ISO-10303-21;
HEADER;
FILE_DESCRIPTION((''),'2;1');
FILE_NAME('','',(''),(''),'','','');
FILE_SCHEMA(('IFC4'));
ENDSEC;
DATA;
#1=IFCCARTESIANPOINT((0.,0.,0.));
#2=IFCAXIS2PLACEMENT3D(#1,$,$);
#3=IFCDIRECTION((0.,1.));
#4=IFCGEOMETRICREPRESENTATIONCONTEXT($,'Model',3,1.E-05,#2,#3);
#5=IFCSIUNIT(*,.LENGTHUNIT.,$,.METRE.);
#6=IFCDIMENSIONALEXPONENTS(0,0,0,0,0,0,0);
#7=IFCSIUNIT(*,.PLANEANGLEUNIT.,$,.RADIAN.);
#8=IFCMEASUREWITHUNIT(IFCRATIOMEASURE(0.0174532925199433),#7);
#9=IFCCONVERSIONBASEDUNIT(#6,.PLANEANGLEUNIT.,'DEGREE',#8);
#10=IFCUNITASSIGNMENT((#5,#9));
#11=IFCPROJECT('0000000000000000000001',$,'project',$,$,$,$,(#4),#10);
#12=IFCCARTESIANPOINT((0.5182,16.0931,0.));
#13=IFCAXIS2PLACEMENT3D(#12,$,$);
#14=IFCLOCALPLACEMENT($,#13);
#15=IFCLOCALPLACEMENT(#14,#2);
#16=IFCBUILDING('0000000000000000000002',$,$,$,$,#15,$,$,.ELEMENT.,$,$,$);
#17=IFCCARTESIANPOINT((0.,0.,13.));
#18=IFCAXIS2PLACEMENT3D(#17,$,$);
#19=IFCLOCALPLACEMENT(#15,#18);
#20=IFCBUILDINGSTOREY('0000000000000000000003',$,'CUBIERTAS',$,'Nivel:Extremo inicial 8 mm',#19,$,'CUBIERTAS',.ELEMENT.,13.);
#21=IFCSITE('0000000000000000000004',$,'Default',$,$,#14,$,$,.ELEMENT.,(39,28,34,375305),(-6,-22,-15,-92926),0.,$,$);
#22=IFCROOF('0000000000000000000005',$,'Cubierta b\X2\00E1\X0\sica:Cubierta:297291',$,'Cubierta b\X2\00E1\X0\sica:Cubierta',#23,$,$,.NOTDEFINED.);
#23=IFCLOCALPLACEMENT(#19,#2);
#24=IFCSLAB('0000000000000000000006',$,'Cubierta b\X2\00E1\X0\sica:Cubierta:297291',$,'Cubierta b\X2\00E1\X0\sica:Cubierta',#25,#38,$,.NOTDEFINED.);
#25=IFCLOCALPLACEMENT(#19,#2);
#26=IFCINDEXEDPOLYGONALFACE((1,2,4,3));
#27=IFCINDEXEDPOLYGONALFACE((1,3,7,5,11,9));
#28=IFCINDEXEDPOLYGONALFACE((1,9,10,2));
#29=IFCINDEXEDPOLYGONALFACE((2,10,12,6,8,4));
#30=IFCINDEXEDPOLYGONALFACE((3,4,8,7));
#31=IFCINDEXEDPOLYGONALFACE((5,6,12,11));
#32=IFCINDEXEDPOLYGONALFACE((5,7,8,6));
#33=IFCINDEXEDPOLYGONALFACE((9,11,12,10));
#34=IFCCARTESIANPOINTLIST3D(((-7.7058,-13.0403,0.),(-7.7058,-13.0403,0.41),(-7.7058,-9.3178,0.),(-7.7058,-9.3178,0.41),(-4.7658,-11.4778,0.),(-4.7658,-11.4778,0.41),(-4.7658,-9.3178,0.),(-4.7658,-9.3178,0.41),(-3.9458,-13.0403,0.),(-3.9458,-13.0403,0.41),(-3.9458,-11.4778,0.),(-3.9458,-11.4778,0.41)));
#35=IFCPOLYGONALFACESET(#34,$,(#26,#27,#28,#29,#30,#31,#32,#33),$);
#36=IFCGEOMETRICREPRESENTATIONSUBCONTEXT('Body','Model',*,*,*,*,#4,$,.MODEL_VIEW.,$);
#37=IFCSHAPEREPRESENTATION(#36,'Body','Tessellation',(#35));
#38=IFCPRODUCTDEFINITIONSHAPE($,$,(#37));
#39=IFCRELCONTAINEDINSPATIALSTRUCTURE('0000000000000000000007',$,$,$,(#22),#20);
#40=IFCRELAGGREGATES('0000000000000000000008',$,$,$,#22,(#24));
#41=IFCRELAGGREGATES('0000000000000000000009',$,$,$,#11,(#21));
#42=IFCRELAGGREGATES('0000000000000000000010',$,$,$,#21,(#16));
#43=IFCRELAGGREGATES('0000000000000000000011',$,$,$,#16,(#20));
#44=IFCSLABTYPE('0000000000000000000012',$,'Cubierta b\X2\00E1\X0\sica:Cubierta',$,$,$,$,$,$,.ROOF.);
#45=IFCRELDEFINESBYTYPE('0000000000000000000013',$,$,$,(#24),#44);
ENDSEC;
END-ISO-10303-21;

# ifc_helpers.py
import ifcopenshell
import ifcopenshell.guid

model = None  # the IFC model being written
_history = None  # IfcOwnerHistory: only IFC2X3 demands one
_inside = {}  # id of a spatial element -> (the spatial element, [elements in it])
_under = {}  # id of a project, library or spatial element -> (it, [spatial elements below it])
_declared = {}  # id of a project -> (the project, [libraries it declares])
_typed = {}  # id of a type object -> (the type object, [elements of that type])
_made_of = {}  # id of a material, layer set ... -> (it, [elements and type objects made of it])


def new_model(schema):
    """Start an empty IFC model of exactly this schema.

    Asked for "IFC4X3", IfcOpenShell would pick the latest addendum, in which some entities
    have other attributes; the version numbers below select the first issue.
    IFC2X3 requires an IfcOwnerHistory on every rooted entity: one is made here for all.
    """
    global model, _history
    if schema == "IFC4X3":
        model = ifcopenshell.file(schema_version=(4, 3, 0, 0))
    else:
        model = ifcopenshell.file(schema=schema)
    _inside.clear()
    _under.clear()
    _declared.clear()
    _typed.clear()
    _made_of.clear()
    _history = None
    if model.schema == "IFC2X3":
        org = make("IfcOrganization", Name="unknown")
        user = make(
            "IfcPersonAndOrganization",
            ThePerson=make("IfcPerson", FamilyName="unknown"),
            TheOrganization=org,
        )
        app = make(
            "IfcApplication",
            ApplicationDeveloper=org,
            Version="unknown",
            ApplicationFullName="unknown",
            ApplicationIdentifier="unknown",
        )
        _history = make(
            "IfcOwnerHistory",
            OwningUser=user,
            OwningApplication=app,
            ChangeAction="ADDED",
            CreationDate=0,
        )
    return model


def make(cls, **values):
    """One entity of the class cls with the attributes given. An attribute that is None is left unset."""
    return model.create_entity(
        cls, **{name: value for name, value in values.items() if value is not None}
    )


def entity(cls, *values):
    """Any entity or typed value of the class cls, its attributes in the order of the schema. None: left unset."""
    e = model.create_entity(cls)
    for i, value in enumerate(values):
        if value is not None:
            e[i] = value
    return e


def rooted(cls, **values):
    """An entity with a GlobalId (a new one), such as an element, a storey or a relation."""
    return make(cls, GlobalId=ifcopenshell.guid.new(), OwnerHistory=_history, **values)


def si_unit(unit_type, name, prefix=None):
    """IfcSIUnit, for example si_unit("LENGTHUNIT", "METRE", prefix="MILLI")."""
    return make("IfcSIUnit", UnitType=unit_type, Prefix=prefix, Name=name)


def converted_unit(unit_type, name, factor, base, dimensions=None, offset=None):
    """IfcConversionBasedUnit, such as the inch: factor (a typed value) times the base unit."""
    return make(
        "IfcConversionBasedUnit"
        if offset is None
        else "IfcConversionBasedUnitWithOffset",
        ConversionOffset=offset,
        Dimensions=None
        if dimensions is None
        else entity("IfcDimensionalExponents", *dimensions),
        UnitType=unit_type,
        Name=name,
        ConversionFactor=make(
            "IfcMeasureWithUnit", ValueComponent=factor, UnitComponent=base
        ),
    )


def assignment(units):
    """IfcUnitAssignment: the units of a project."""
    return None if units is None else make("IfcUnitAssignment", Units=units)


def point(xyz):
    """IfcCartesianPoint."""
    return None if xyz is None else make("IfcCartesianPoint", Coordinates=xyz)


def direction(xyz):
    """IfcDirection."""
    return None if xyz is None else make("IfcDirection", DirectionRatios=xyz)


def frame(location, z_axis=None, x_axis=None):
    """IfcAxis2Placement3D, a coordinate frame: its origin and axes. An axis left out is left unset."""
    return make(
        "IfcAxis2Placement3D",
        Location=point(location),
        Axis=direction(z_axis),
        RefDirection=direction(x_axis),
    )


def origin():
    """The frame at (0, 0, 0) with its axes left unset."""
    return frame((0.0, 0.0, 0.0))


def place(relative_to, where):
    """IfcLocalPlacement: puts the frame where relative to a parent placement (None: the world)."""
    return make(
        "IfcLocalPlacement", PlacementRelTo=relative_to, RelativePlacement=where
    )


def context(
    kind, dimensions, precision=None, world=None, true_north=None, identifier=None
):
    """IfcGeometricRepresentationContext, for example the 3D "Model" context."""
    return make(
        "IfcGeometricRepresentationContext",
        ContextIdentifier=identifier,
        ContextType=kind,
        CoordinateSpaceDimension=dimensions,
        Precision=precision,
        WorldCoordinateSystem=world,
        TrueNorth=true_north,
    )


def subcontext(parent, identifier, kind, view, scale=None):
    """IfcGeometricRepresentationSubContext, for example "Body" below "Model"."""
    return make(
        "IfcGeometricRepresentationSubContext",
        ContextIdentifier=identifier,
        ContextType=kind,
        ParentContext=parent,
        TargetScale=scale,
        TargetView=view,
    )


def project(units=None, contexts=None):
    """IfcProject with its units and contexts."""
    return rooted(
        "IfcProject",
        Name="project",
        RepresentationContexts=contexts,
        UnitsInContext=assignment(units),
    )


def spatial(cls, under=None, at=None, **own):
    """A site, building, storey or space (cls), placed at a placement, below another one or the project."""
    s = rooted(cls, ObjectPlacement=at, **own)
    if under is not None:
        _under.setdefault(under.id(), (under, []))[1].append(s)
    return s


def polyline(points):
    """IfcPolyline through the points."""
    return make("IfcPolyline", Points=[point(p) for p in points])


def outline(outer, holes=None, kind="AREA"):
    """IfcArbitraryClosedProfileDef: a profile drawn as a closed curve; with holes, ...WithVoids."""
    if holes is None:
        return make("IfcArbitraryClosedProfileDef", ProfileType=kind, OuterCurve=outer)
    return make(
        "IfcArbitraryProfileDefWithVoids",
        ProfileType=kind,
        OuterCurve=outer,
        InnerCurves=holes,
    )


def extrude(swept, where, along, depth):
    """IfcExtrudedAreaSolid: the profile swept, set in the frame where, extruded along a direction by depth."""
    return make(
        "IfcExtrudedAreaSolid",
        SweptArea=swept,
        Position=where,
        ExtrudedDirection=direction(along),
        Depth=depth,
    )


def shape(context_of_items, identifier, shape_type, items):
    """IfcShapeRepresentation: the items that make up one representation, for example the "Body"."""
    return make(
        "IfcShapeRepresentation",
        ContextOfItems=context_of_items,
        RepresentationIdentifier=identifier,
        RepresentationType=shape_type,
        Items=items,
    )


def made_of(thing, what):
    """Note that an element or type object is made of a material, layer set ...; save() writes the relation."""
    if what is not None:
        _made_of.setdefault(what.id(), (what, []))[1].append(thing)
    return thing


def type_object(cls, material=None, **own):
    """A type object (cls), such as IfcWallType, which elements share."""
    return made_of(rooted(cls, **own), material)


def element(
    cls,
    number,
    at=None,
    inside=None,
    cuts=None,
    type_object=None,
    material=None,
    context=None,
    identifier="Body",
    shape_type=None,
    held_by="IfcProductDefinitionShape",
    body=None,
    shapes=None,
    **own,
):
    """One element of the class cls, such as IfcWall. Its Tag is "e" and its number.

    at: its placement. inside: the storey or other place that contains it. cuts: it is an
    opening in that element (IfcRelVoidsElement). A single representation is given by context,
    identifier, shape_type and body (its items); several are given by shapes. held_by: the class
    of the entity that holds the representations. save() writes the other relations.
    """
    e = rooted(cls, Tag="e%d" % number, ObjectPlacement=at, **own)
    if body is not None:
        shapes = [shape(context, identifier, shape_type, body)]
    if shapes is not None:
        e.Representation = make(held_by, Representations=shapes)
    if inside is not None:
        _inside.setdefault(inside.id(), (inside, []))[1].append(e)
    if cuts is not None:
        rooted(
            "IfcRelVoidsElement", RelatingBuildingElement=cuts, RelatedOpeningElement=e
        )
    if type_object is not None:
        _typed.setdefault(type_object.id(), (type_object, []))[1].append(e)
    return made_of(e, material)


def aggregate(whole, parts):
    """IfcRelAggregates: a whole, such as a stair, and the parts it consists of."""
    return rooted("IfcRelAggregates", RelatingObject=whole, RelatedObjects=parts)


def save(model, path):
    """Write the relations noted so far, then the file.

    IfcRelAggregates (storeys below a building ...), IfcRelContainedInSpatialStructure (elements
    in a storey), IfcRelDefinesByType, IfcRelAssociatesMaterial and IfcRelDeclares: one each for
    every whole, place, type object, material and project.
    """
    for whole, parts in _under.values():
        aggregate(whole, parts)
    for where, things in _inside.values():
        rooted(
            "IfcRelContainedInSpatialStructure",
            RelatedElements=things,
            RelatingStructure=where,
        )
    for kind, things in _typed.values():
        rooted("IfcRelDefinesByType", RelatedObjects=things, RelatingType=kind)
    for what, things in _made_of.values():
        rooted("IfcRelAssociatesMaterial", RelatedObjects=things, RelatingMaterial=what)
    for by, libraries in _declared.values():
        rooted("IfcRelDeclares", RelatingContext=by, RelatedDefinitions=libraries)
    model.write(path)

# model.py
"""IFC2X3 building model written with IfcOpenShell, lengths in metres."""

from ifc_helpers import new_model, entity, si_unit, converted_unit, direction, frame, origin, place, context, subcontext, project, spatial, polyline, outline, extrude, type_object, element, aggregate, save


model = new_model("IFC2X3")

# Units and contexts
model_context = context("Model", 3, precision=1e-05, world=origin(), true_north=direction((0.0, 1.0)))
body_context = subcontext(model_context, "Body", "Model", "MODEL_VIEW")
ifc_project = project(units=[si_unit("LENGTHUNIT", "METRE"), converted_unit("PLANEANGLEUNIT", "DEGREE", entity("IfcRatioMeasure", 0.0174532925199433), si_unit("PLANEANGLEUNIT", "RADIAN"), dimensions=[0, 0, 0, 0, 0, 0, 0])], contexts=[model_context])

# Site, building, storey
site_placement = place(None, frame((0.5182, 16.0931, 0.0)))
site = spatial("IfcSite", under=ifc_project, at=site_placement, Name="Default", CompositionType="ELEMENT", RefLatitude=(39, 28, 34, 375305), RefLongitude=(-6, -22, -15, -92926), RefElevation=0.0)
building_placement = place(site_placement, origin())
building = spatial("IfcBuilding", under=site, at=building_placement, CompositionType="ELEMENT")
storey_placement = place(building_placement, frame((0.0, 0.0, 13.0)))
storey = spatial("IfcBuildingStorey", under=building, at=storey_placement, Name="CUBIERTAS", ObjectType="Nivel:Extremo inicial 8 mm", LongName="CUBIERTAS", CompositionType="ELEMENT", Elevation=13.0)

# Roof, slab
roof_placement = place(storey_placement, frame((-7.7058, -13.0403, 0.0)))
roof = element("IfcRoof", 1, at=roof_placement, inside=storey, Name="Cubierta básica:Cubierta:297291", ObjectType="Cubierta básica:Cubierta", ShapeType="NOTDEFINED")
slab_type = type_object("IfcSlabType", Name="Cubierta básica:Cubierta", PredefinedType="ROOF")
slab_placement = place(roof_placement, origin())
slab = element("IfcSlab", 2, at=slab_placement, type_object=slab_type, Name="Cubierta básica:Cubierta:297291", ObjectType="Cubierta básica:Cubierta", PredefinedType="NOTDEFINED", context=body_context, shape_type="SweptSolid", body=[
    extrude(outline(polyline([(-1.88, 1.8613), (-1.88, -1.8613), (1.88, -1.8613), (1.88, -0.2988), (1.06, -0.2988), (1.06, 1.8613), (-1.88, 1.8613)])), frame((1.88, 1.8613, 0.0)), (0.0, 0.0, 1.0), 0.41),
])
aggregate(roof, [slab])

save(model, "model.ifc")
